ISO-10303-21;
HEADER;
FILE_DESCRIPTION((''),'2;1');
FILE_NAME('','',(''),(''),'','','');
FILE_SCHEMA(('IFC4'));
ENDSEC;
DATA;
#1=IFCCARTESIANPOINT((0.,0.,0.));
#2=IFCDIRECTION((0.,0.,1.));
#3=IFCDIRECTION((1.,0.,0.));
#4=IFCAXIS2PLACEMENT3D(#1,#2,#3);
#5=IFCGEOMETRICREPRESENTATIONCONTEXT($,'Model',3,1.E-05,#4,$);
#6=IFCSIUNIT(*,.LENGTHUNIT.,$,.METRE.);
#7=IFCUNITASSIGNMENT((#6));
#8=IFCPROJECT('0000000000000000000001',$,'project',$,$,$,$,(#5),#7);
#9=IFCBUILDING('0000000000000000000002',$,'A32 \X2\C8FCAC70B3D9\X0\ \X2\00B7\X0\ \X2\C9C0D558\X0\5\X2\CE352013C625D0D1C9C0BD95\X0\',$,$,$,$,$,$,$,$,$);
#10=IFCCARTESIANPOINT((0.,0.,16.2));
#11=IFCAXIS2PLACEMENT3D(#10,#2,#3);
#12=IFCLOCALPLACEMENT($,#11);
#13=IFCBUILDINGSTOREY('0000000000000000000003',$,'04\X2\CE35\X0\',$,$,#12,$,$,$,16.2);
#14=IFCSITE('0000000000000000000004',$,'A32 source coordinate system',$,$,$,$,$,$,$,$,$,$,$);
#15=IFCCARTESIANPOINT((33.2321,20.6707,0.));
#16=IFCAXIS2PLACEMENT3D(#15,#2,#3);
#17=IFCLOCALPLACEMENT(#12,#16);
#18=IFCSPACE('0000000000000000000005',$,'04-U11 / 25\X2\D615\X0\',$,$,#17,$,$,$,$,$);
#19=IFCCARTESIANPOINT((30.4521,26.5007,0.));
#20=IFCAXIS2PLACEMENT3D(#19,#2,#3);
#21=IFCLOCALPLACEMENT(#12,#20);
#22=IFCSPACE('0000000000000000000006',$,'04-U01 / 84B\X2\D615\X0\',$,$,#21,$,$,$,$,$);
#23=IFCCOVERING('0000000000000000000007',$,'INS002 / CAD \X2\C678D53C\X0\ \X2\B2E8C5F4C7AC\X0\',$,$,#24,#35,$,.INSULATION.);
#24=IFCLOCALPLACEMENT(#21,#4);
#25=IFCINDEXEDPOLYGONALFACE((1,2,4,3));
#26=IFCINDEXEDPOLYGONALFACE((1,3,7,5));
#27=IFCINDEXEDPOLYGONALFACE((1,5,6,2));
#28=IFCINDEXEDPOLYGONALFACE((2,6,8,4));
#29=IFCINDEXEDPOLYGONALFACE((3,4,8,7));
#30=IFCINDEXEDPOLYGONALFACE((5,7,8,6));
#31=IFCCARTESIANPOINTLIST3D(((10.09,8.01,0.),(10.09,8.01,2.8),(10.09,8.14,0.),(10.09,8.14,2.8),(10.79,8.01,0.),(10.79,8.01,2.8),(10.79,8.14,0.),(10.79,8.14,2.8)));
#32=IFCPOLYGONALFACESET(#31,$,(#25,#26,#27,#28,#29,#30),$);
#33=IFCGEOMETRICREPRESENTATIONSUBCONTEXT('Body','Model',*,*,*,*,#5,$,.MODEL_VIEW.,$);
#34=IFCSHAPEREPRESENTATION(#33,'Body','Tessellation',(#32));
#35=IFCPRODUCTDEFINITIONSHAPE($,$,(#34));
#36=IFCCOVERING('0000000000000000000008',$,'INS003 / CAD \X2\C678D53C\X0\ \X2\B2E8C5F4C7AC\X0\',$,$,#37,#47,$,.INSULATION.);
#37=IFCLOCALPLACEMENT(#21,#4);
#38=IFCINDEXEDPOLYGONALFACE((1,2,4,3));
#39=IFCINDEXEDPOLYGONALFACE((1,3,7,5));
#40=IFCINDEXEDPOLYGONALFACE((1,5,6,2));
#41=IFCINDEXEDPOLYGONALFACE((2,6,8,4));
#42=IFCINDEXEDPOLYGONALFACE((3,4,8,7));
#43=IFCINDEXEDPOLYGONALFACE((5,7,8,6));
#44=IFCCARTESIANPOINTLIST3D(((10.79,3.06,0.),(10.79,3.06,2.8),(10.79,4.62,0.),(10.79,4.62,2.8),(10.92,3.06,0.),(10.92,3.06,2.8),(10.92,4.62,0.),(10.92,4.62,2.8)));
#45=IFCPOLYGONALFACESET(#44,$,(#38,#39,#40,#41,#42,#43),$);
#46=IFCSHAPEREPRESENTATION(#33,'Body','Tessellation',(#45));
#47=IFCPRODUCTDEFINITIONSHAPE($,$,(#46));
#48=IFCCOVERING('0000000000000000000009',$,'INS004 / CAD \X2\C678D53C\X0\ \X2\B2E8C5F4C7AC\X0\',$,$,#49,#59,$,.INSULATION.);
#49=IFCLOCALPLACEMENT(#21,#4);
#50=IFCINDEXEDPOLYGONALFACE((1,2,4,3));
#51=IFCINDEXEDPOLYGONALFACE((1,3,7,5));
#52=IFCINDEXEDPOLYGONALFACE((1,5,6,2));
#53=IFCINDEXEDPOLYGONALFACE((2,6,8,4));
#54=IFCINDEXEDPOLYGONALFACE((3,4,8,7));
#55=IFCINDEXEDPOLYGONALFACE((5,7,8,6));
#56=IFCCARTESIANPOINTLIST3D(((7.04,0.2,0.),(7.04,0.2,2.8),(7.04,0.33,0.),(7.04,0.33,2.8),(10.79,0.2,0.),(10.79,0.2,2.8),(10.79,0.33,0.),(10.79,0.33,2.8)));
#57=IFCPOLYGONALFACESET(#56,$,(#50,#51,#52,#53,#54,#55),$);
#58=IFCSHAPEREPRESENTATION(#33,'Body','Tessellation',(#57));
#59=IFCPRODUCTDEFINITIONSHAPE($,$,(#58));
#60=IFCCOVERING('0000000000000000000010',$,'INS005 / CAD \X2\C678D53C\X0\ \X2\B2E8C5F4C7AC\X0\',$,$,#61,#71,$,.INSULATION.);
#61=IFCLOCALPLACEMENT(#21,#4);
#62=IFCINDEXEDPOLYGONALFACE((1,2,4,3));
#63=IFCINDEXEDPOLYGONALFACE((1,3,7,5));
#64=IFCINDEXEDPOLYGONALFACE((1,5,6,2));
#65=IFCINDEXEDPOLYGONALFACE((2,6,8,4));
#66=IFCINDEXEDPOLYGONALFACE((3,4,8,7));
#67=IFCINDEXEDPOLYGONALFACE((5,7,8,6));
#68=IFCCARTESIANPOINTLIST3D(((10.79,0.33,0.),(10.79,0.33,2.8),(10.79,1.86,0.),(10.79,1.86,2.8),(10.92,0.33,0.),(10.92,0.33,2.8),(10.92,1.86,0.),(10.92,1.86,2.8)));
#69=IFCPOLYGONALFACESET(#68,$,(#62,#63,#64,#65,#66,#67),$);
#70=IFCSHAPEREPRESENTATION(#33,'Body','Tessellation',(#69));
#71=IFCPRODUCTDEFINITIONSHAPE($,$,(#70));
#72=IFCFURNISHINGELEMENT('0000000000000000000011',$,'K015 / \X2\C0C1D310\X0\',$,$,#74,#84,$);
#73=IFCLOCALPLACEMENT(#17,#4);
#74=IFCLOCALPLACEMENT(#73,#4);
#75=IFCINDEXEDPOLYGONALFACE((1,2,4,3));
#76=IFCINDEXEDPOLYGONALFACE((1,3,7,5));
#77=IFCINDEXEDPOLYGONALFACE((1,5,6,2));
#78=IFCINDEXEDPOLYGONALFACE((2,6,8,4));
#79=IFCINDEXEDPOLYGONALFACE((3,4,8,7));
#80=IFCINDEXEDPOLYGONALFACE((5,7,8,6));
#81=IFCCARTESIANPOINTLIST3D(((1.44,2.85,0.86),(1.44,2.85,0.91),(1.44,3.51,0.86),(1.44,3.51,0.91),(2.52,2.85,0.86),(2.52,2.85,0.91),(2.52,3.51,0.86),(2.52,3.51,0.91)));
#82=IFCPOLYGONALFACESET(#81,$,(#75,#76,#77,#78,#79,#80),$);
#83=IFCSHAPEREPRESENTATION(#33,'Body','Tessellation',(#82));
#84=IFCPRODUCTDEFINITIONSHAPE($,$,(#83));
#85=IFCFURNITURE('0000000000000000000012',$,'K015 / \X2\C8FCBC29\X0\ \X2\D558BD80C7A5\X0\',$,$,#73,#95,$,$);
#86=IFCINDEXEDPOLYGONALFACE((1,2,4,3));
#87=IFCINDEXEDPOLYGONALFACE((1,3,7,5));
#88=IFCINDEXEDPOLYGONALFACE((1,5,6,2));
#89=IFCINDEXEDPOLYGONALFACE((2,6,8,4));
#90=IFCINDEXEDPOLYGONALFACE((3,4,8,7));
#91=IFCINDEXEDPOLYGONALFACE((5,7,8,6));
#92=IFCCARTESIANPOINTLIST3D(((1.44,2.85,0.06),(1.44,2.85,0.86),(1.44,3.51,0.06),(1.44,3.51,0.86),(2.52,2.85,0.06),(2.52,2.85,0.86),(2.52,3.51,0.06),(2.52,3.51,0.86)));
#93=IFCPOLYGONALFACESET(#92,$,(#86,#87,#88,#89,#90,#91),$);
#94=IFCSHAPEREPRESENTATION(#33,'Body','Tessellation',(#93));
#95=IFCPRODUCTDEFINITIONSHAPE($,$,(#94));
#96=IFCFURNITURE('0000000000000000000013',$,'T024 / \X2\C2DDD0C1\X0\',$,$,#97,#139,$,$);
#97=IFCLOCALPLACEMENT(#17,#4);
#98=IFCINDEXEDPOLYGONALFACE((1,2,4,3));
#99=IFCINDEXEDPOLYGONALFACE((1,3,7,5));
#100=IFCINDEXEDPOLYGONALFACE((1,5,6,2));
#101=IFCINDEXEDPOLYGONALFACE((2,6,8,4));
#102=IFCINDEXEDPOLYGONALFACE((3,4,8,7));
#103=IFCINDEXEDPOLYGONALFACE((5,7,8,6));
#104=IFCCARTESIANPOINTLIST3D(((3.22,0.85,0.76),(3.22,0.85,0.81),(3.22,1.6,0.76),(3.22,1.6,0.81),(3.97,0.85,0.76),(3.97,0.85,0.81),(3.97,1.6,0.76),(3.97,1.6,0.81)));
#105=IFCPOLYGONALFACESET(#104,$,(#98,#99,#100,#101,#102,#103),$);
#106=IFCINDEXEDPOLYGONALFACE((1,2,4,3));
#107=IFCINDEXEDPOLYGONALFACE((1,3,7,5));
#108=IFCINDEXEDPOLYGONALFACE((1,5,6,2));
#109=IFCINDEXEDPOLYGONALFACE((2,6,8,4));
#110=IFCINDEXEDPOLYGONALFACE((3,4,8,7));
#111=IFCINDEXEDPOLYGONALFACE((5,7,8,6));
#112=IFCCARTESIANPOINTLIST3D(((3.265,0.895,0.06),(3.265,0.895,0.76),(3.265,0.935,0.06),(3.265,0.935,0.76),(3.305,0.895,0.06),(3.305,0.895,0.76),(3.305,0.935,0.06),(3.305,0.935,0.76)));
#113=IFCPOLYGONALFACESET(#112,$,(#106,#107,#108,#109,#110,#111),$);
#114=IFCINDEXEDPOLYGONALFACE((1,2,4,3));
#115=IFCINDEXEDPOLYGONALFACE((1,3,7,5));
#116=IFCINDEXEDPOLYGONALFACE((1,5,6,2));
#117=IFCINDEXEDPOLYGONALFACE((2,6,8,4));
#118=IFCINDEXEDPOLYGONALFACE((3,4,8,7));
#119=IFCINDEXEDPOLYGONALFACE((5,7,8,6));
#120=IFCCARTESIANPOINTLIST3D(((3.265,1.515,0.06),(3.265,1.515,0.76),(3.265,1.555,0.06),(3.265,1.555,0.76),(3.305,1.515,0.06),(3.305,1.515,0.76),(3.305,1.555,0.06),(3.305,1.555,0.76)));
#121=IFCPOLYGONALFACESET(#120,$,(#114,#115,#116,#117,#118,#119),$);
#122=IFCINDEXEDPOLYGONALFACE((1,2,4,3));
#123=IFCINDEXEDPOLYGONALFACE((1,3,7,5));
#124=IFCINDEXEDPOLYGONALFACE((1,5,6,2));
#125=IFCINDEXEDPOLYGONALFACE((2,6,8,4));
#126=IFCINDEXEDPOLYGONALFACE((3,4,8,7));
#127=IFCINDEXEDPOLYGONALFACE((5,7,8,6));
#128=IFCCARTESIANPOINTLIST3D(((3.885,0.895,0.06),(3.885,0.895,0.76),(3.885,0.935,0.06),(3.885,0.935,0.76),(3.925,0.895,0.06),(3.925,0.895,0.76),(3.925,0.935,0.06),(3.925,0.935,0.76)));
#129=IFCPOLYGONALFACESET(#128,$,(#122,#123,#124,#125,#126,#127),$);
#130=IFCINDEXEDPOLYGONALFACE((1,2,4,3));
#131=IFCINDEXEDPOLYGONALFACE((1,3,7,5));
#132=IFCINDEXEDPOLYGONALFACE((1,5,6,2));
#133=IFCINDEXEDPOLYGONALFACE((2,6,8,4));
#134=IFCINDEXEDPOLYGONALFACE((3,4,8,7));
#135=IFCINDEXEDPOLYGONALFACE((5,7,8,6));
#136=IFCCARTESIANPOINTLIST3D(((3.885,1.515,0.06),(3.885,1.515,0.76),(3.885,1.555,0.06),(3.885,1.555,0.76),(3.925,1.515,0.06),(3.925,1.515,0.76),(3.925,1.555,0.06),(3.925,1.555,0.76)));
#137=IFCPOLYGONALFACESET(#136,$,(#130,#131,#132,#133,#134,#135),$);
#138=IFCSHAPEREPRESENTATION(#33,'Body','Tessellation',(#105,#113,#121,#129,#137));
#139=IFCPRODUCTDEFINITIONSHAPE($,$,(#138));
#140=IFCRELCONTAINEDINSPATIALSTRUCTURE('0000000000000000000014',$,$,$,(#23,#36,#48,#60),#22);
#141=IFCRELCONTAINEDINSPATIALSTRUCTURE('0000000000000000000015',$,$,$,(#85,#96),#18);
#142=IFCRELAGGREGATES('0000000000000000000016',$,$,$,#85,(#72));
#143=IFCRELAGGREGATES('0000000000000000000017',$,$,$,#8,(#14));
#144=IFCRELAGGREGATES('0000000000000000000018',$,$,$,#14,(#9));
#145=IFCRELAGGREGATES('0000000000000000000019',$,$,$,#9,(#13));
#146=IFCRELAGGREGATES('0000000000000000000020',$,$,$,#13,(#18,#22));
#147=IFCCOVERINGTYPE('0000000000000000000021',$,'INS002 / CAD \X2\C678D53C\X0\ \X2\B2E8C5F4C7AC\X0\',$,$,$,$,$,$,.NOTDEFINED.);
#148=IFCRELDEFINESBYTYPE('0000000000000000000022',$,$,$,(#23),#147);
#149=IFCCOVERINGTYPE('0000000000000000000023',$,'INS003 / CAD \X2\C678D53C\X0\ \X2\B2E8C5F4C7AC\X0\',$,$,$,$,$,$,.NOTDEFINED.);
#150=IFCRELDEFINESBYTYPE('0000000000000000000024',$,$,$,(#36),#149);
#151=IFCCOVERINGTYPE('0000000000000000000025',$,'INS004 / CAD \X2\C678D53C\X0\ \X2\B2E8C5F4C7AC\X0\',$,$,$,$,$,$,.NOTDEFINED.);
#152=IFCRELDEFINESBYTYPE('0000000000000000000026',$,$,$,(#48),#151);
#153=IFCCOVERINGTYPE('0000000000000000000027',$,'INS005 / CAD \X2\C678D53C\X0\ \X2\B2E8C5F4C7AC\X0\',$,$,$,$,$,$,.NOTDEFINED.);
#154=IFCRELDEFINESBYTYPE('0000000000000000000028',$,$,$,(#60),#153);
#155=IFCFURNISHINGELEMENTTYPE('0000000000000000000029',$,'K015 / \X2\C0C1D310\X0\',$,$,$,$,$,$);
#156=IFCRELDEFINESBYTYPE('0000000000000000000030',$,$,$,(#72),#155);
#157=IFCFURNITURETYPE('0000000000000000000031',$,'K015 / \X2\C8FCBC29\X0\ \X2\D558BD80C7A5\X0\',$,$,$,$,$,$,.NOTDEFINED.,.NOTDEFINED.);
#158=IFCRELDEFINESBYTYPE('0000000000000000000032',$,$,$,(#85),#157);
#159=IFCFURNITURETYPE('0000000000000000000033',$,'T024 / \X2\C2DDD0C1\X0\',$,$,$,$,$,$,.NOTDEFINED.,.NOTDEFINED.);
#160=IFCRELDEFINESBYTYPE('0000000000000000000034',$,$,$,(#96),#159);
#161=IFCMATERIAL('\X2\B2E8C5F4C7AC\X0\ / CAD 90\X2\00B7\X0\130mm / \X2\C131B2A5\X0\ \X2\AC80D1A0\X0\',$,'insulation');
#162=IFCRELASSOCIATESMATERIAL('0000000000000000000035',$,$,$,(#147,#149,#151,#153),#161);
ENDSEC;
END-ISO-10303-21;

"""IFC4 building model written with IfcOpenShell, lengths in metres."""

from ifc_helpers import new_model, si_unit, frame, origin, origin_with_axes, place, context, subcontext, project, spatial, polyline, outline, extrude, source, transform, mapped, material, type_object, type_shapes, element, aggregate, save


model = new_model("IFC4")

# Units and contexts
model_context = context("Model", 3, precision=1e-05, world=origin_with_axes())
body_context = subcontext(model_context, "Body", "Model", "MODEL_VIEW")
ifc_project = project(units=[si_unit("LENGTHUNIT", "METRE")], contexts=[model_context])

# Site, building, storey, space
site = spatial("IfcSite", under=ifc_project, Name="A32 source coordinate system")
building = spatial("IfcBuilding", under=site, Name="A32 주거동 · 지하5층–옥탑지붕")
storey_placement = place(None, frame((0.0, 0.0, 16.2), z_axis=(0.0, 0.0, 1.0), x_axis=(1.0, 0.0, 0.0)))
storey = spatial("IfcBuildingStorey", under=building, at=storey_placement, Name="04층", Elevation=16.2)
space_1_placement = place(storey_placement, frame((33.2321, 20.6707, 0.0), z_axis=(0.0, 0.0, 1.0), x_axis=(1.0, 0.0, 0.0)))
space_1 = spatial("IfcSpace", under=storey, at=space_1_placement, Name="04-U11 / 25형")

# Shared definitions
space_2_placement = place(storey_placement, frame((30.4521, 26.5007, 0.0), z_axis=(0.0, 0.0, 1.0), x_axis=(1.0, 0.0, 0.0)))
space_2 = spatial("IfcSpace", under=storey, at=space_2_placement, Name="04-U01 / 84B형")

# Coverings
ifc_material = material(Name="단열재 / CAD 90·130mm / 성능 검토", Category="insulation")
covering_type_1 = type_object("IfcCoveringType", Name="INS002 / CAD 외피 단열재", PredefinedType="NOTDEFINED", material=ifc_material)
shared_shape_1 = source(origin(), body_context, "Body", "SweptSolid", [
    extrude(outline(polyline([(10.79, 8.01), (10.09, 8.01), (10.09, 8.14), (10.79, 8.14), (10.79, 8.01)])), origin(), (0.0, 0.0, 1.0), 2.8),
])
type_shapes(covering_type_1, [shared_shape_1])
covering_1_placement = place(space_2_placement, origin_with_axes())
element("IfcCovering", 1, at=covering_1_placement, inside=space_2, type_object=covering_type_1, Name="INS002 / CAD 외피 단열재", PredefinedType="INSULATION", context=body_context, shape_type="MappedRepresentation", body=[
    mapped(shared_shape_1, transform((0.0, 0.0, 0.0), scale=1.0)),
])
covering_type_2 = type_object("IfcCoveringType", Name="INS003 / CAD 외피 단열재", PredefinedType="NOTDEFINED", material=ifc_material)
shared_shape_2 = source(origin(), body_context, "Body", "SweptSolid", [
    extrude(outline(polyline([(10.79, 3.06), (10.79, 4.62), (10.92, 4.62), (10.92, 3.06), (10.79, 3.06)])), origin(), (0.0, 0.0, 1.0), 2.8),
])
type_shapes(covering_type_2, [shared_shape_2])
covering_2_placement = place(space_2_placement, origin_with_axes())
element("IfcCovering", 2, at=covering_2_placement, inside=space_2, type_object=covering_type_2, Name="INS003 / CAD 외피 단열재", PredefinedType="INSULATION", context=body_context, shape_type="MappedRepresentation", body=[
    mapped(shared_shape_2, transform((0.0, 0.0, 0.0), scale=1.0)),
])
covering_type_3 = type_object("IfcCoveringType", Name="INS004 / CAD 외피 단열재", PredefinedType="NOTDEFINED", material=ifc_material)
shared_shape_3 = source(origin(), body_context, "Body", "SweptSolid", [
    extrude(outline(polyline([(7.04, 0.33), (10.79, 0.33), (10.79, 0.2), (7.04, 0.2), (7.04, 0.33)])), origin(), (0.0, 0.0, 1.0), 2.8),
])
type_shapes(covering_type_3, [shared_shape_3])
covering_3_placement = place(space_2_placement, origin_with_axes())
element("IfcCovering", 3, at=covering_3_placement, inside=space_2, type_object=covering_type_3, Name="INS004 / CAD 외피 단열재", PredefinedType="INSULATION", context=body_context, shape_type="MappedRepresentation", body=[
    mapped(shared_shape_3, transform((0.0, 0.0, 0.0), scale=1.0)),
])
covering_type_4 = type_object("IfcCoveringType", Name="INS005 / CAD 외피 단열재", PredefinedType="NOTDEFINED", material=ifc_material)
shared_shape_4 = source(origin(), body_context, "Body", "SweptSolid", [
    extrude(outline(polyline([(10.79, 0.33), (10.79, 1.86), (10.92, 1.86), (10.92, 0.33), (10.79, 0.33)])), origin(), (0.0, 0.0, 1.0), 2.8),
])
type_shapes(covering_type_4, [shared_shape_4])
covering_4_placement = place(space_2_placement, origin_with_axes())
element("IfcCovering", 4, at=covering_4_placement, inside=space_2, type_object=covering_type_4, Name="INS005 / CAD 외피 단열재", PredefinedType="INSULATION", context=body_context, shape_type="MappedRepresentation", body=[
    mapped(shared_shape_4, transform((0.0, 0.0, 0.0), scale=1.0)),
])

# Furnishing element
furnishing_element_type_1 = type_object("IfcFurnishingElementType", Name="K015 / 상판")
shared_shape_5 = source(origin(), body_context, "Body", "SweptSolid", [
    extrude(outline(polyline([(2.52, 2.85), (1.44, 2.85), (1.44, 3.51), (2.52, 3.51), (2.52, 2.85)])), frame((0.0, 0.0, 0.86)), (0.0, 0.0, 1.0), 0.05),
])
type_shapes(furnishing_element_type_1, [shared_shape_5])
furniture_1_placement = place(space_1_placement, origin_with_axes())
furnishing_1_placement = place(furniture_1_placement, origin_with_axes())
furnishing_1 = element("IfcFurnishingElement", 5, at=furnishing_1_placement, type_object=furnishing_element_type_1, Name="K015 / 상판", context=body_context, shape_type="MappedRepresentation", body=[
    mapped(shared_shape_5, transform((0.0, 0.0, 0.0), scale=1.0)),
])

# Furniture
furniture_type_1 = type_object("IfcFurnitureType", Name="K015 / 주방 하부장", AssemblyPlace="NOTDEFINED", PredefinedType="NOTDEFINED")
shared_shape_6 = source(origin(), body_context, "Body", "SweptSolid", [
    extrude(outline(polyline([(2.52, 3.51), (2.52, 2.85), (1.44, 2.85), (1.44, 3.51), (2.52, 3.51)])), frame((0.0, 0.0, 0.06)), (0.0, 0.0, 1.0), 0.8),
])
type_shapes(furniture_type_1, [shared_shape_6])
furniture_1 = element("IfcFurniture", 6, at=furniture_1_placement, inside=space_1, type_object=furniture_type_1, Name="K015 / 주방 하부장", context=body_context, shape_type="MappedRepresentation", body=[
    mapped(shared_shape_6, transform((0.0, 0.0, 0.0), scale=1.0)),
])
aggregate(furniture_1, [furnishing_1])
furniture_type_2 = type_object("IfcFurnitureType", Name="T024 / 식탁", AssemblyPlace="NOTDEFINED", PredefinedType="NOTDEFINED")
shared_shape_7 = source(origin(), body_context, "Body", "SweptSolid", [
    extrude(outline(polyline([(3.22, 0.85), (3.22, 1.6), (3.97, 1.6), (3.97, 0.85), (3.22, 0.85)])), frame((0.0, 0.0, 0.76)), (0.0, 0.0, 1.0), 0.05),
    extrude(outline(polyline([(3.265, 0.895), (3.265, 0.935), (3.305, 0.935), (3.305, 0.895), (3.265, 0.895)])), frame((0.0, 0.0, 0.06)), (0.0, 0.0, 1.0), 0.7),
    extrude(outline(polyline([(3.265, 1.515), (3.265, 1.555), (3.305, 1.555), (3.305, 1.515), (3.265, 1.515)])), frame((0.0, 0.0, 0.06)), (0.0, 0.0, 1.0), 0.7),
    extrude(outline(polyline([(3.885, 0.895), (3.885, 0.935), (3.925, 0.935), (3.925, 0.895), (3.885, 0.895)])), frame((0.0, 0.0, 0.06)), (0.0, 0.0, 1.0), 0.7),
    extrude(outline(polyline([(3.885, 1.515), (3.885, 1.555), (3.925, 1.555), (3.925, 1.515), (3.885, 1.515)])), frame((0.0, 0.0, 0.06)), (0.0, 0.0, 1.0), 0.7),
])
type_shapes(furniture_type_2, [shared_shape_7])
furniture_2_placement = place(space_1_placement, origin_with_axes())
element("IfcFurniture", 7, at=furniture_2_placement, inside=space_1, type_object=furniture_type_2, Name="T024 / 식탁", context=body_context, shape_type="MappedRepresentation", body=[
    mapped(shared_shape_7, transform((0.0, 0.0, 0.0), scale=1.0)),
])

save(model, "model.ifc")
